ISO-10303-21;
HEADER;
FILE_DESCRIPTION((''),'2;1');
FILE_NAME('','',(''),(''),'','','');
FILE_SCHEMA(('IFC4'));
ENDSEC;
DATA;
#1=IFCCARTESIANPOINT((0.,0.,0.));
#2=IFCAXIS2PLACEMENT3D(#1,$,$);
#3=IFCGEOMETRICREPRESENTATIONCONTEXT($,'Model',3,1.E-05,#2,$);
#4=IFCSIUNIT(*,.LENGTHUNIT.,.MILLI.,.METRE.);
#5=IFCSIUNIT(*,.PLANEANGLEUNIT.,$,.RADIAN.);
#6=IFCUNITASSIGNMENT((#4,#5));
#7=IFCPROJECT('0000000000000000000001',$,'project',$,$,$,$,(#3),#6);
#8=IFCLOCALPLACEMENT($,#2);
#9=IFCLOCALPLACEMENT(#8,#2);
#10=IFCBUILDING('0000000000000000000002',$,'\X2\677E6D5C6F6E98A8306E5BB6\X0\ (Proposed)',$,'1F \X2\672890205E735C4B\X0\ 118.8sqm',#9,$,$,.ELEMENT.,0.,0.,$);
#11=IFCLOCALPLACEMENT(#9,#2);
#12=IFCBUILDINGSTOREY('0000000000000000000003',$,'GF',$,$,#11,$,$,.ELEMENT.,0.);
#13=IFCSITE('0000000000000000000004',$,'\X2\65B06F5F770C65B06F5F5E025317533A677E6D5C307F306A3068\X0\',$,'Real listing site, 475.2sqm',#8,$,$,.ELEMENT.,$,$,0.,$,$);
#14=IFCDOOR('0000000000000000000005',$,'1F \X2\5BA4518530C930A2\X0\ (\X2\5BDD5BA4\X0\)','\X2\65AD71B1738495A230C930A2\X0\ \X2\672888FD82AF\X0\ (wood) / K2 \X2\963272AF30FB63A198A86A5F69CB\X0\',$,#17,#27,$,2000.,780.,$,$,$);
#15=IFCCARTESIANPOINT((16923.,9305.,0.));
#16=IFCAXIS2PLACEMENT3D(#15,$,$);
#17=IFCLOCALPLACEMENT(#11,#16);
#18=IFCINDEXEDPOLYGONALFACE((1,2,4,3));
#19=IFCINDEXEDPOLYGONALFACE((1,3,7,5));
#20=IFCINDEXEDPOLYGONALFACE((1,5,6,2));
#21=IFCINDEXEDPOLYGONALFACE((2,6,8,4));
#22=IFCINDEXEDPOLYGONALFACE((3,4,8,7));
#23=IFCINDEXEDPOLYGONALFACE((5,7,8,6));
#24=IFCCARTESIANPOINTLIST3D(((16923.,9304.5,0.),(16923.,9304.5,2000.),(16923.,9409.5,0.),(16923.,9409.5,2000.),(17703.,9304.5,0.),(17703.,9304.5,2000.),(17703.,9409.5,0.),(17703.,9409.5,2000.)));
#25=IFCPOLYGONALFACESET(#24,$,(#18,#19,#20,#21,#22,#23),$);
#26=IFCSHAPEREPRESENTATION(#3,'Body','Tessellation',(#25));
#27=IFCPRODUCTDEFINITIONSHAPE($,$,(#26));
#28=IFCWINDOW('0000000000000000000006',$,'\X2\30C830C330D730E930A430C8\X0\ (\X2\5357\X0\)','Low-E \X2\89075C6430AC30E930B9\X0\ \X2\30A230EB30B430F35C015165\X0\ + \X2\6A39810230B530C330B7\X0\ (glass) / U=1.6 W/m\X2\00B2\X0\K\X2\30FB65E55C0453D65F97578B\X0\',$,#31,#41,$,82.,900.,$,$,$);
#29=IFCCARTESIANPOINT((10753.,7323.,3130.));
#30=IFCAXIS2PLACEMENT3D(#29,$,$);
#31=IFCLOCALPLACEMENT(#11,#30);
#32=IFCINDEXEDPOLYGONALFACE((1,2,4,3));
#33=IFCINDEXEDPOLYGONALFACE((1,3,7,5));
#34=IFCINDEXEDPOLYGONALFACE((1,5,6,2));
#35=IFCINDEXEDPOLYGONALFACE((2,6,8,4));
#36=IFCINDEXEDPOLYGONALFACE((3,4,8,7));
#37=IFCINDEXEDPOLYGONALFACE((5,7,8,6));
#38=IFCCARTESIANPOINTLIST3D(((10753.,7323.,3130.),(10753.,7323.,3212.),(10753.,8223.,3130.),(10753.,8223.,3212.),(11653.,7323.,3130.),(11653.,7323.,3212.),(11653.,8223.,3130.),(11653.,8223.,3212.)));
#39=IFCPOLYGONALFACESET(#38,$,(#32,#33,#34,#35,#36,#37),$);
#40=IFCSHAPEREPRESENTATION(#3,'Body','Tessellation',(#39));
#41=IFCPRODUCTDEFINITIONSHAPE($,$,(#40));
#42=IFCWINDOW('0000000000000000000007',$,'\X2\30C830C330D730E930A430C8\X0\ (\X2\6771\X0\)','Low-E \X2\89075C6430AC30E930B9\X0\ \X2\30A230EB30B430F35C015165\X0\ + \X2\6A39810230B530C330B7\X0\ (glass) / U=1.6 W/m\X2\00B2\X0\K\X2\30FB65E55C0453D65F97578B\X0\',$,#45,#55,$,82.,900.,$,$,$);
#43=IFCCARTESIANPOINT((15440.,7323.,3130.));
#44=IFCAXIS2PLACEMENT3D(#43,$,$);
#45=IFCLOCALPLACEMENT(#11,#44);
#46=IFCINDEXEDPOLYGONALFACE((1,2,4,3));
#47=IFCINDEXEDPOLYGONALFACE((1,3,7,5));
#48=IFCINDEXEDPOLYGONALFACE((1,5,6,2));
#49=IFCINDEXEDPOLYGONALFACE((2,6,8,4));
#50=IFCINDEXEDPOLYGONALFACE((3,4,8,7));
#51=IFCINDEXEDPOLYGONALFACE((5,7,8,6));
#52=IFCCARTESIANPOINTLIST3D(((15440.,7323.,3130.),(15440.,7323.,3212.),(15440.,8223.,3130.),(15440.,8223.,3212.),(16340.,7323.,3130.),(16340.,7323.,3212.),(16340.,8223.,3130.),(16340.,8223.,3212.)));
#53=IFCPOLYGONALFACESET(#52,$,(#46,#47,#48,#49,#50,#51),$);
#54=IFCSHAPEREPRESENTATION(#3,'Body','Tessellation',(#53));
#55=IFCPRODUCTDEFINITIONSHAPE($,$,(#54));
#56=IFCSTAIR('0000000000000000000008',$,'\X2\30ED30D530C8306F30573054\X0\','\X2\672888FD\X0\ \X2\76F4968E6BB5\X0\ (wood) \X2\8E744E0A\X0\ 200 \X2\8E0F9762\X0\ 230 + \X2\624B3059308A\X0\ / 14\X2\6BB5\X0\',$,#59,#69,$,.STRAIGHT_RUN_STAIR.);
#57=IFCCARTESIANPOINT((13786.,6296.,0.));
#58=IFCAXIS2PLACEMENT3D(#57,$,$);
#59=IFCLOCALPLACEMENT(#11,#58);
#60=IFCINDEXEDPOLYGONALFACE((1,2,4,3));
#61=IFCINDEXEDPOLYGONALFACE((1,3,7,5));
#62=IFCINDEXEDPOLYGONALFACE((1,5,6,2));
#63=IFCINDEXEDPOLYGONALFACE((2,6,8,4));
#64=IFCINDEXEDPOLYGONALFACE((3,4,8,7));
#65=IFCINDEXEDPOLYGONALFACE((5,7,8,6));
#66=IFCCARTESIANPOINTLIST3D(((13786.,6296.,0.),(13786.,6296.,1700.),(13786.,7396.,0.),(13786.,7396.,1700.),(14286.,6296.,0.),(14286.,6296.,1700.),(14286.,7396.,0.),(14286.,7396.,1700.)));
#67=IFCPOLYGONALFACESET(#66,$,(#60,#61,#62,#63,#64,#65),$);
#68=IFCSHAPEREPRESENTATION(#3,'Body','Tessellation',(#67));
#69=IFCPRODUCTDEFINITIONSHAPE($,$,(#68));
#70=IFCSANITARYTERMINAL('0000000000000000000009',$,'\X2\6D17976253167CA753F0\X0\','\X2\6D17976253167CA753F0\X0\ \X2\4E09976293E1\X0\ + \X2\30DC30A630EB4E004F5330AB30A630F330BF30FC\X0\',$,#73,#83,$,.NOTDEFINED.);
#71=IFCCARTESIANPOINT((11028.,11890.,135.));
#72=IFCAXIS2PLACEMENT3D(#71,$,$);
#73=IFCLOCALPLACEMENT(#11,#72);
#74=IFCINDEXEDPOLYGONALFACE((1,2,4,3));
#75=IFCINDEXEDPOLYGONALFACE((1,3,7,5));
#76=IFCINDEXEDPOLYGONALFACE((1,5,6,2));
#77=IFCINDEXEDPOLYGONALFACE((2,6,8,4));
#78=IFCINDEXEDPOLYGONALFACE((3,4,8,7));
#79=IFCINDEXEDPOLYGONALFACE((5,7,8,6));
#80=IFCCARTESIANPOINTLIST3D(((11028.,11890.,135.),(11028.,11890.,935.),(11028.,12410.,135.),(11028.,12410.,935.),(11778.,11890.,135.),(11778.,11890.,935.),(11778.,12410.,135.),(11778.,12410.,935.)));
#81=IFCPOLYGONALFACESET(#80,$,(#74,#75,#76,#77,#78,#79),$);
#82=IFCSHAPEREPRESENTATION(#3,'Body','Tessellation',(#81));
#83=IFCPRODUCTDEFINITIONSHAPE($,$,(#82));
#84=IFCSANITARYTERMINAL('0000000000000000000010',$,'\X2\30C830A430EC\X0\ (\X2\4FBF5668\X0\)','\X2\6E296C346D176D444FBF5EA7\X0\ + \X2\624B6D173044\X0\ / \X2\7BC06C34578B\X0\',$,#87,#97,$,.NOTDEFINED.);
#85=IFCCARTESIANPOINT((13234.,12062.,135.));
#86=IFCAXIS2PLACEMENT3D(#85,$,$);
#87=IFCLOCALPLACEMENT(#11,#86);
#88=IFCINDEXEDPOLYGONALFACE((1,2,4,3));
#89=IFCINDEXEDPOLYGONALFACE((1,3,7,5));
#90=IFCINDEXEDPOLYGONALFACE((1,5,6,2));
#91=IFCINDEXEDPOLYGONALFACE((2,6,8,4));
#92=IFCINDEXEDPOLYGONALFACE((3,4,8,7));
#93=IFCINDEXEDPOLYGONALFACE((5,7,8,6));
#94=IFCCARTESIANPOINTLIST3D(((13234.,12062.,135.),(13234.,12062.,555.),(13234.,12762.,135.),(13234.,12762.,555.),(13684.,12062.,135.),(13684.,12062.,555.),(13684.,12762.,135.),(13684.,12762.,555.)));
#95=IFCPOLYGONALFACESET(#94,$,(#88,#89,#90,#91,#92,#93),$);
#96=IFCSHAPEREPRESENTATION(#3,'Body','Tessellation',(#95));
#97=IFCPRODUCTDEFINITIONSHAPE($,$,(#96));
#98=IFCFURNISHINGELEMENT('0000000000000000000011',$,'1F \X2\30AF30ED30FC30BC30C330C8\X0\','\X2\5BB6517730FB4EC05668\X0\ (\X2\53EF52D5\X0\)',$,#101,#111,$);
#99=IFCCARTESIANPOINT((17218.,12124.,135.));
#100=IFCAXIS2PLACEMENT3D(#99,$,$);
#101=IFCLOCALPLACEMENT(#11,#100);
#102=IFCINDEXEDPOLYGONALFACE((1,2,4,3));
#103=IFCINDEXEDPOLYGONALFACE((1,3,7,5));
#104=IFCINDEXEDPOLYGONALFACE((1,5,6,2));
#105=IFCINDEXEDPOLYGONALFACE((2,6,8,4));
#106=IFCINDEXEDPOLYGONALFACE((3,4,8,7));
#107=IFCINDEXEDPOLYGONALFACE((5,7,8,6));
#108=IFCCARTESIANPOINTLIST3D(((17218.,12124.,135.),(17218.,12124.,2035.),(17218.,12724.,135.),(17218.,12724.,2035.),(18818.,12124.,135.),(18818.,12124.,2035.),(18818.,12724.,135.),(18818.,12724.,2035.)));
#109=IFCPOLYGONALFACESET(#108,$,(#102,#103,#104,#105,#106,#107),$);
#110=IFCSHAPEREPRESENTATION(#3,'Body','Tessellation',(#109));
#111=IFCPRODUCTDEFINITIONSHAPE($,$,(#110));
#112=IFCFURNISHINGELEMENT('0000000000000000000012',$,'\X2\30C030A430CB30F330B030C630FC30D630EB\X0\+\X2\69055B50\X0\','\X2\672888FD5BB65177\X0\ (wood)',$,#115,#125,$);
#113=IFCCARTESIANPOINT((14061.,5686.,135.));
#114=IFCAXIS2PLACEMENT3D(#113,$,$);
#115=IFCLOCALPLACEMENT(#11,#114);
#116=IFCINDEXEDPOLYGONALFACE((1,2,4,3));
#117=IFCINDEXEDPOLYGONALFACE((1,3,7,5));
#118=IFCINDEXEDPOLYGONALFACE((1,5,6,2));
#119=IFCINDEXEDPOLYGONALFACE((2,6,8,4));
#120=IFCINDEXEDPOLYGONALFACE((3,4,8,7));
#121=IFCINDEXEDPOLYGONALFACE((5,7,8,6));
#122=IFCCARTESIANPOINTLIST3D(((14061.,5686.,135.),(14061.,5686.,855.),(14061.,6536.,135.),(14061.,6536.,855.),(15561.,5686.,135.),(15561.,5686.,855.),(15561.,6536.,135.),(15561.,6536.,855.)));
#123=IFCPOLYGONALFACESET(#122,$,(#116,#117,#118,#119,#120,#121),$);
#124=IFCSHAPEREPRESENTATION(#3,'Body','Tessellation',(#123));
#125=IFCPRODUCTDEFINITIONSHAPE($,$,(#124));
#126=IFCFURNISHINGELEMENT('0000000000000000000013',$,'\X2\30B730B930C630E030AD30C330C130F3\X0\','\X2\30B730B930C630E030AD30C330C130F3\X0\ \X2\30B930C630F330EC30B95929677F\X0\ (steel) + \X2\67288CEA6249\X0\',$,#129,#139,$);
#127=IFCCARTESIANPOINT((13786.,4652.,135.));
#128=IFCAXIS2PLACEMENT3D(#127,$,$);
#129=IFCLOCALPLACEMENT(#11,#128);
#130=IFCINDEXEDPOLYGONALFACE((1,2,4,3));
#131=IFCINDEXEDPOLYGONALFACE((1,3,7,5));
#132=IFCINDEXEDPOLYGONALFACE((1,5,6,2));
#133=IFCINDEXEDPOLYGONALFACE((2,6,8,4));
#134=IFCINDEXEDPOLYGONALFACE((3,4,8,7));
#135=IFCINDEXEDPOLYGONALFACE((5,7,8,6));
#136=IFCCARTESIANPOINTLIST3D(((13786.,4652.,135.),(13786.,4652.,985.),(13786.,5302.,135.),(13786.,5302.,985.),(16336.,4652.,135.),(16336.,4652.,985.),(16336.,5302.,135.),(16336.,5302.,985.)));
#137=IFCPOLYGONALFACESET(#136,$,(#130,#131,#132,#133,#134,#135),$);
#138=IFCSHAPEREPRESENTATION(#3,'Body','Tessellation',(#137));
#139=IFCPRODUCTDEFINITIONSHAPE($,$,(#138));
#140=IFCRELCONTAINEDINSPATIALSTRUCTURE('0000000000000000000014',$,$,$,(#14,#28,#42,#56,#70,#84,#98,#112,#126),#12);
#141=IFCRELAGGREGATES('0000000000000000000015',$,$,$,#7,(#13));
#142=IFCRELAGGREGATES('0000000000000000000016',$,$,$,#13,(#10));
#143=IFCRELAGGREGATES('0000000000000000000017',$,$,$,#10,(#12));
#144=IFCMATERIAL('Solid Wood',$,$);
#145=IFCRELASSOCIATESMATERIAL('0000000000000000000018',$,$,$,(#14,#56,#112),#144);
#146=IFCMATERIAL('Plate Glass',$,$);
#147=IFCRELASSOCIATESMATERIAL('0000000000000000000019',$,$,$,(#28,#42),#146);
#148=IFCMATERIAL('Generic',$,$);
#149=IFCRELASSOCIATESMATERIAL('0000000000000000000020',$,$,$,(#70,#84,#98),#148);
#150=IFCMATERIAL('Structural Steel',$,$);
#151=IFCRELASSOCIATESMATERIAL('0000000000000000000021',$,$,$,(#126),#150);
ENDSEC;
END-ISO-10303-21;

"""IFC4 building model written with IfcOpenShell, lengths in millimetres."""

from ifc_helpers import new_model, si_unit, frame, frame_2d, origin, place, context, project, spatial, rectangle, extrude, material, element, save


model = new_model("IFC4")

# Units and contexts
model_context = context("Model", 3, precision=1e-05, world=origin())
ifc_project = project(units=[si_unit("LENGTHUNIT", "METRE", prefix="MILLI"), si_unit("PLANEANGLEUNIT", "RADIAN")], contexts=[model_context])

# Site, building, storey
site_placement = place(None, origin())
site = spatial("IfcSite", under=ifc_project, at=site_placement, Name="新潟県新潟市北区松浜みなと", ObjectType="Real listing site, 475.2sqm", CompositionType="ELEMENT", RefElevation=0.0)
building_placement = place(site_placement, origin())
building = spatial("IfcBuilding", under=site, at=building_placement, Name="松浜潮風の家 (Proposed)", ObjectType="1F 木造平屋 118.8sqm", CompositionType="ELEMENT", ElevationOfRefHeight=0.0, ElevationOfTerrain=0.0)
storey_placement = place(building_placement, origin())
storey = spatial("IfcBuildingStorey", under=building, at=storey_placement, Name="GF", CompositionType="ELEMENT", Elevation=0.0)

# Shared definitions
ifc_material_1 = material(Name="Solid Wood")
ifc_material_2 = material(Name="Plate Glass")

# Door
door_placement = place(storey_placement, frame((16923.0, 9305.0, 0.0)))
element("IfcDoor", 1, at=door_placement, inside=storey, material=ifc_material_1, Name="1F 室内ドア (寝室)", Description="断熱玄関ドア 木製芯 (wood) / K2 防犯・採風機構", OverallHeight=2000.0, OverallWidth=780.0, context=model_context, shape_type="SweptSolid", body=[
    extrude(rectangle(XDim=780.0, YDim=105.0, at=frame_2d((390.0, 52.0))), frame((16923.0, 9305.0, 0.0)), (0.0, 0.0, 1.0), 2000.0),
])

# Windows
window_1_placement = place(storey_placement, frame((10753.0, 7323.0, 3130.0)))
element("IfcWindow", 2, at=window_1_placement, inside=storey, material=ifc_material_2, Name="トップライト (南)", Description="Low-E 複層ガラス アルゴン封入 + 樹脂サッシ (glass) / U=1.6 W/m²K・日射取得型", OverallHeight=82.0, OverallWidth=900.0, context=model_context, shape_type="SweptSolid", body=[
    extrude(rectangle(XDim=900.0, YDim=900.0, at=frame_2d((450.0, 450.0))), frame((10753.0, 7323.0, 3130.0)), (0.0, 0.0, 1.0), 82.0),
])
window_2_placement = place(storey_placement, frame((15440.0, 7323.0, 3130.0)))
element("IfcWindow", 3, at=window_2_placement, inside=storey, material=ifc_material_2, Name="トップライト (東)", Description="Low-E 複層ガラス アルゴン封入 + 樹脂サッシ (glass) / U=1.6 W/m²K・日射取得型", OverallHeight=82.0, OverallWidth=900.0, context=model_context, shape_type="SweptSolid", body=[
    extrude(rectangle(XDim=900.0, YDim=900.0, at=frame_2d((450.0, 450.0))), frame((15440.0, 7323.0, 3130.0)), (0.0, 0.0, 1.0), 82.0),
])

# Stair
stair_placement = place(storey_placement, frame((13786.0, 6296.0, 0.0)))
element("IfcStair", 4, at=stair_placement, inside=storey, material=ifc_material_1, Name="ロフトはしご", Description="木製 直階段 (wood) 蹴上 200 踏面 230 + 手すり / 14段", PredefinedType="STRAIGHT_RUN_STAIR", context=model_context, shape_type="SweptSolid", body=[
    extrude(rectangle(XDim=500.0, YDim=1100.0, at=frame_2d((250.0, 550.0))), frame((13786.0, 6296.0, 0.0)), (0.0, 0.0, 1.0), 1700.0),
])

# Sanitary terminals
ifc_material_3 = material(Name="Generic")
sanitary_terminal_1_placement = place(storey_placement, frame((11028.0, 11890.0, 135.0)))
element("IfcSanitaryTerminal", 5, at=sanitary_terminal_1_placement, inside=storey, material=ifc_material_3, Name="洗面化粧台", Description="洗面化粧台 三面鏡 + ボウル一体カウンター", PredefinedType="NOTDEFINED", context=model_context, shape_type="SweptSolid", body=[
    extrude(rectangle(XDim=750.0, YDim=520.0, at=frame_2d((375.0, 260.0))), frame((11028.0, 11890.0, 135.0)), (0.0, 0.0, 1.0), 800.0),
])
sanitary_terminal_2_placement = place(storey_placement, frame((13234.0, 12062.0, 135.0)))
element("IfcSanitaryTerminal", 6, at=sanitary_terminal_2_placement, inside=storey, material=ifc_material_3, Name="トイレ (便器)", Description="温水洗浄便座 + 手洗い / 節水型", PredefinedType="NOTDEFINED", context=model_context, shape_type="SweptSolid", body=[
    extrude(rectangle(XDim=450.0, YDim=700.0, at=frame_2d((225.0, 350.0))), frame((13234.0, 12062.0, 135.0)), (0.0, 0.0, 1.0), 420.0),
])

# Furnishing elements
furnishing_1_placement = place(storey_placement, frame((17218.0, 12124.0, 135.0)))
element("IfcFurnishingElement", 7, at=furnishing_1_placement, inside=storey, material=ifc_material_3, Name="1F クローゼット", Description="家具・什器 (可動)", context=model_context, shape_type="SweptSolid", body=[
    extrude(rectangle(XDim=1600.0, YDim=600.0, at=frame_2d((800.0, 300.0))), frame((17218.0, 12124.0, 135.0)), (0.0, 0.0, 1.0), 1900.0),
])
furnishing_2_placement = place(storey_placement, frame((14061.0, 5686.0, 135.0)))
element("IfcFurnishingElement", 8, at=furnishing_2_placement, inside=storey, material=ifc_material_1, Name="ダイニングテーブル+椅子", Description="木製家具 (wood)", context=model_context, shape_type="SweptSolid", body=[
    extrude(rectangle(XDim=1500.0, YDim=850.0, at=frame_2d((750.0, 425.0))), frame((14061.0, 5686.0, 135.0)), (0.0, 0.0, 1.0), 720.0),
])
ifc_material_4 = material(Name="Structural Steel")
furnishing_3_placement = place(storey_placement, frame((13786.0, 4652.0, 135.0)))
element("IfcFurnishingElement", 9, at=furnishing_3_placement, inside=storey, material=ifc_material_4, Name="システムキッチン", Description="システムキッチン ステンレス天板 (steel) + 木質扉", context=model_context, shape_type="SweptSolid", body=[
    extrude(rectangle(XDim=2550.0, YDim=650.0, at=frame_2d((1275.0, 325.0))), frame((13786.0, 4652.0, 135.0)), (0.0, 0.0, 1.0), 850.0),
])

save(model, "model.ifc")
